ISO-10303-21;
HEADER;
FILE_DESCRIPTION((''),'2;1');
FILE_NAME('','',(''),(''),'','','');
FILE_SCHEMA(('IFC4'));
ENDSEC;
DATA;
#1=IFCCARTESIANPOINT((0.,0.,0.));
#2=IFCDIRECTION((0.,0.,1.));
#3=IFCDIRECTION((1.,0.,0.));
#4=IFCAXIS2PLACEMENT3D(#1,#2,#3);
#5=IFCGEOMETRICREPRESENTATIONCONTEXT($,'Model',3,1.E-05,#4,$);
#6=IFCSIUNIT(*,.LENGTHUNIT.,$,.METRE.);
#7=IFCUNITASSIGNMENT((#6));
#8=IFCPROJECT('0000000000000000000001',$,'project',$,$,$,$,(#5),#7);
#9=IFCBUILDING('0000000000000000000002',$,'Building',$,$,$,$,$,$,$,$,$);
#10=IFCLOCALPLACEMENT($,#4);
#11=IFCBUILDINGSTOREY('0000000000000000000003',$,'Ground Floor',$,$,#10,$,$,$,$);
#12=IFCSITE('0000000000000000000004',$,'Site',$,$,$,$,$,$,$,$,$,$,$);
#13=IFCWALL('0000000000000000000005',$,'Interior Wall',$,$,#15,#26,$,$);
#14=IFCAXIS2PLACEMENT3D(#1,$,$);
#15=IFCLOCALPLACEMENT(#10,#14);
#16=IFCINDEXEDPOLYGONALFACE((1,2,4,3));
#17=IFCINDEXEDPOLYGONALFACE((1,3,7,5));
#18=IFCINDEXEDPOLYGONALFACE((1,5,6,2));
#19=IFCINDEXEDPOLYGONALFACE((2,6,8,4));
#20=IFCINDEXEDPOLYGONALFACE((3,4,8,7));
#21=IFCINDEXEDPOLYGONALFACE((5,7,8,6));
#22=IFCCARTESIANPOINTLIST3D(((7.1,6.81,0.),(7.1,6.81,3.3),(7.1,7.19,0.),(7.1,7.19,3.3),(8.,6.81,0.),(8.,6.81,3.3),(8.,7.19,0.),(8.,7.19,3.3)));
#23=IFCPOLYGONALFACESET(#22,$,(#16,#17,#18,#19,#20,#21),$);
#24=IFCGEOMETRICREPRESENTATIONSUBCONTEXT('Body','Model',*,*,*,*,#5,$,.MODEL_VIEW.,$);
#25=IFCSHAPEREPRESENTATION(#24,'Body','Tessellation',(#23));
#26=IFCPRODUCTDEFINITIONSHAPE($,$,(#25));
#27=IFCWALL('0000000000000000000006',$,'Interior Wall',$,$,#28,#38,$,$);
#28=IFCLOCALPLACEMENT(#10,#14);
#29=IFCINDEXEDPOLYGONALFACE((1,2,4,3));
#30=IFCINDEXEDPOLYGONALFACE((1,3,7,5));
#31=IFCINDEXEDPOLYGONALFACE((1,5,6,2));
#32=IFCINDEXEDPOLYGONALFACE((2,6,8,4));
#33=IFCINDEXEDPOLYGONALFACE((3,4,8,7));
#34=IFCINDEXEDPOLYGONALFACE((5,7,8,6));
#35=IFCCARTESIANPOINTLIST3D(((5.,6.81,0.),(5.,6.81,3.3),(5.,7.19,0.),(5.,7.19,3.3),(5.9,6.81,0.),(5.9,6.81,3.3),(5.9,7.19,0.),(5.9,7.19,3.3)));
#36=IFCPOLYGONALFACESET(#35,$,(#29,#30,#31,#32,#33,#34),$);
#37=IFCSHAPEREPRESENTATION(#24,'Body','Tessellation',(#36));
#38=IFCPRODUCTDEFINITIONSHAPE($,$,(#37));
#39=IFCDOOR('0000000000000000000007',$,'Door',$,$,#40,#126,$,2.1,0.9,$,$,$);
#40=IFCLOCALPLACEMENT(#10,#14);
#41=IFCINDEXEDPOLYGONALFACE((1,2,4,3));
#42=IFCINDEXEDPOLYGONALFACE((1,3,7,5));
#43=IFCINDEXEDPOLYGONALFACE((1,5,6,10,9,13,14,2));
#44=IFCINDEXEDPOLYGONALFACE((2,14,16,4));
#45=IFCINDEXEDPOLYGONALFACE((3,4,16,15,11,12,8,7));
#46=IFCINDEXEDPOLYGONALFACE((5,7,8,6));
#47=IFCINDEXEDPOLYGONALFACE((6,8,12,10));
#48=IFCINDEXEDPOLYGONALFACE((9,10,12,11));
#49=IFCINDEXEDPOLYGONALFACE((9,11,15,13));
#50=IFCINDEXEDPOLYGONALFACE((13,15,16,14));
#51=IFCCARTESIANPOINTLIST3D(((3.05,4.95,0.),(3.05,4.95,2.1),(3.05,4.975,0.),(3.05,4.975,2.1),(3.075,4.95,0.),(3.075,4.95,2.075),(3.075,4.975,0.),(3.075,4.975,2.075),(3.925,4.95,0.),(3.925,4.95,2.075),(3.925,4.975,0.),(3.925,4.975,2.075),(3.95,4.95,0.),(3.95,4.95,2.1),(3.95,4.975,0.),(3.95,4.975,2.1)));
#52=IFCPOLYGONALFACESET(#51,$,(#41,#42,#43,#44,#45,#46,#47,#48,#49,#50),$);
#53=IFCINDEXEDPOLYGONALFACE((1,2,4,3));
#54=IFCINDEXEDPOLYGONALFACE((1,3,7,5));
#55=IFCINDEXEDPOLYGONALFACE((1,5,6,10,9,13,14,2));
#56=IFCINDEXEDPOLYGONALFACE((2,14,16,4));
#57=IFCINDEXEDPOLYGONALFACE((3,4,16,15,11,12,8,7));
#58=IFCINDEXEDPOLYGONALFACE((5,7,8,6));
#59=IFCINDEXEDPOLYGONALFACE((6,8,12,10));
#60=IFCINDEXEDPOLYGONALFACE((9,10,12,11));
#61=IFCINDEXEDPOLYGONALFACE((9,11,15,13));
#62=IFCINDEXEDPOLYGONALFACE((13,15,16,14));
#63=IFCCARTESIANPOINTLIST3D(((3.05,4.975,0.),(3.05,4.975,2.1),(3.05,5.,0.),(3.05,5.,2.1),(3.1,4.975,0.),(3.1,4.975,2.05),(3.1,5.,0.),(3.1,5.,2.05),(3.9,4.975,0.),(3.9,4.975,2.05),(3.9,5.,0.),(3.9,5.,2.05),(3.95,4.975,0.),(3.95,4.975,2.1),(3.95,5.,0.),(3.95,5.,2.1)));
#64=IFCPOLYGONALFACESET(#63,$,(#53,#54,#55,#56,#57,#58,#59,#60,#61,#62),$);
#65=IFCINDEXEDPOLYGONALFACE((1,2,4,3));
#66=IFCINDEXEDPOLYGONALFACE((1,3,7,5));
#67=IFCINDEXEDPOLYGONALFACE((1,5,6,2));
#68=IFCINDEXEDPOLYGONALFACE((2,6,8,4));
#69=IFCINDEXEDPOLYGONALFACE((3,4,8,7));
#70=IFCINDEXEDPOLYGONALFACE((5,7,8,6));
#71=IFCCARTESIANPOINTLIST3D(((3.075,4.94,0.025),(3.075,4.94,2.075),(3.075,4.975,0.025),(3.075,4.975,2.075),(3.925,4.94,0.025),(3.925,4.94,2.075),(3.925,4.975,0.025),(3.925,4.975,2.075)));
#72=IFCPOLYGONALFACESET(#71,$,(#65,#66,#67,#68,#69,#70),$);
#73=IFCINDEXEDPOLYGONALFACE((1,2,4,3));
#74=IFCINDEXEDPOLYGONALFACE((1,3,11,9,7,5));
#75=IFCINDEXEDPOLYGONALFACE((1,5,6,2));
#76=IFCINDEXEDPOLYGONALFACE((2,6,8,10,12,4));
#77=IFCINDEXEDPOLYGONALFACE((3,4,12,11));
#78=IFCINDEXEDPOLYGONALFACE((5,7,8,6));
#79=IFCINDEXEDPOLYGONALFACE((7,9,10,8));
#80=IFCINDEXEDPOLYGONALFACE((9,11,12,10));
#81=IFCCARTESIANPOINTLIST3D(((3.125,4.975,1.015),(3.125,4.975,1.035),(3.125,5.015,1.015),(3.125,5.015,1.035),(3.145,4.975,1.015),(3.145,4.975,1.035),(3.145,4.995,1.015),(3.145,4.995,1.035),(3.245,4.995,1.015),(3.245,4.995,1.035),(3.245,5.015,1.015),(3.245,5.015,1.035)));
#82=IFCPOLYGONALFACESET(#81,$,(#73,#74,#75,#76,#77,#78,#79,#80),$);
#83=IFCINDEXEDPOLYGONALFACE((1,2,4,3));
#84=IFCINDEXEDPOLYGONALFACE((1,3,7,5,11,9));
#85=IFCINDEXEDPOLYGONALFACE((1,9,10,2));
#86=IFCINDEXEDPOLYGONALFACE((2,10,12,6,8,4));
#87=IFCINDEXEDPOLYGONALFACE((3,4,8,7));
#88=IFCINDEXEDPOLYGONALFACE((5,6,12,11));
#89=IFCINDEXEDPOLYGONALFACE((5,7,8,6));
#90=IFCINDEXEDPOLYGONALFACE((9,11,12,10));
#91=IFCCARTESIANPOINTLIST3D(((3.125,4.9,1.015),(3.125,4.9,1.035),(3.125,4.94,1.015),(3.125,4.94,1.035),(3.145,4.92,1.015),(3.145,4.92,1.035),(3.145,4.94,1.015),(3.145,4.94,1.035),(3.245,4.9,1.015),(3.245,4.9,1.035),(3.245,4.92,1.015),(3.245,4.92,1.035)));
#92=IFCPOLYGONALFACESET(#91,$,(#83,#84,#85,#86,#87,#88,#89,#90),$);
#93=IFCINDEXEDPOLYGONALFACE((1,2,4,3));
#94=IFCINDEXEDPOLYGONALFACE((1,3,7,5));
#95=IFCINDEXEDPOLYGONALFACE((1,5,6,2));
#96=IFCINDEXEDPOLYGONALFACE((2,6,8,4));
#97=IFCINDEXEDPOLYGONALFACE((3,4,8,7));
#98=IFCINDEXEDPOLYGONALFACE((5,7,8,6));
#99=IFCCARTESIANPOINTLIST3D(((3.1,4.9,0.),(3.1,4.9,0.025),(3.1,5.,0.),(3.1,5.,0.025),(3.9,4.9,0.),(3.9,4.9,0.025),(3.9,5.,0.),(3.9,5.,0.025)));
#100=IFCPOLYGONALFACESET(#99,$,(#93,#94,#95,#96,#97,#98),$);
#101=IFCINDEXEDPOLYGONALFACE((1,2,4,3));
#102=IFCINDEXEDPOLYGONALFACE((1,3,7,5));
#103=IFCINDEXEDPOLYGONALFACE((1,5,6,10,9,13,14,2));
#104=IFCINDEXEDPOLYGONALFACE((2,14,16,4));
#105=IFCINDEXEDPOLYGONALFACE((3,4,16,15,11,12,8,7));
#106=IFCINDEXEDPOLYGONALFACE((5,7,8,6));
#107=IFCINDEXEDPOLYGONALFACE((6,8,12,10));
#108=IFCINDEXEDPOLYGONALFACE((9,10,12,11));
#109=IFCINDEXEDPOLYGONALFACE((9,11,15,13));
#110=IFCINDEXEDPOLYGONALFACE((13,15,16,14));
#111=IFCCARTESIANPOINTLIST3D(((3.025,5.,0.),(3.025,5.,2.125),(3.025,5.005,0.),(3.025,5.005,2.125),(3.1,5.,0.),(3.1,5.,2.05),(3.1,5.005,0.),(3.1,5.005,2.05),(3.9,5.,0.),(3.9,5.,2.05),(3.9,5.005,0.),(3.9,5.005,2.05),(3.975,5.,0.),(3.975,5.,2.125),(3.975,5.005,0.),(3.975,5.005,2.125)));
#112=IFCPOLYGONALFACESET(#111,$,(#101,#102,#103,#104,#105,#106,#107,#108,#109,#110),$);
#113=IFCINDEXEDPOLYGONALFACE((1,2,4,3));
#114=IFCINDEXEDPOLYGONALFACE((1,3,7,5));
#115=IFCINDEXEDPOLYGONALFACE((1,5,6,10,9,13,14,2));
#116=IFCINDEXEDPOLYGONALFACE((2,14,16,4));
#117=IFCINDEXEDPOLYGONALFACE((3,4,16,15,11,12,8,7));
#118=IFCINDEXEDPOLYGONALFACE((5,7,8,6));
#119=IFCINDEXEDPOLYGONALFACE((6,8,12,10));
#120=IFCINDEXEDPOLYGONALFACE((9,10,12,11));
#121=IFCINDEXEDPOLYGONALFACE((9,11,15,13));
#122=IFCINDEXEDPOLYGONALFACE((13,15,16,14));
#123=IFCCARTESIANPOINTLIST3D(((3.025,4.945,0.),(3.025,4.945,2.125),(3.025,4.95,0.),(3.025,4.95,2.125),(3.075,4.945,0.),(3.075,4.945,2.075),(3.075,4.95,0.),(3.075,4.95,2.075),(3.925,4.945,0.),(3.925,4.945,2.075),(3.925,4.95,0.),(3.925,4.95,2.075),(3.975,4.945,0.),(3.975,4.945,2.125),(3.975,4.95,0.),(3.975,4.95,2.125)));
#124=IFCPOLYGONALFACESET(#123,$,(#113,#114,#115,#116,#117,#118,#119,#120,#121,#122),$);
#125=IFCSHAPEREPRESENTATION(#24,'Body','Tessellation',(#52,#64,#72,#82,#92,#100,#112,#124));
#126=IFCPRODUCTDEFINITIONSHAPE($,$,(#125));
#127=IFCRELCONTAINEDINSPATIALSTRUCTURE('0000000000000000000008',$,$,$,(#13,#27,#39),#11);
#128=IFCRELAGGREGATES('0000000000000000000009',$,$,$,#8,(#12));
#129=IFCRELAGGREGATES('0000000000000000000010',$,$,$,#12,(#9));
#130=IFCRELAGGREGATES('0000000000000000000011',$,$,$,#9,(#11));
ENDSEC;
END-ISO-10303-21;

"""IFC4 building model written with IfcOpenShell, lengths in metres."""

from ifc_helpers import new_model, si_unit, frame, origin_with_axes, place, context, subcontext, project, spatial, line, indexed_curve, outline, extrude, element, save


model = new_model("IFC4")

# Units and contexts
model_context = context("Model", 3, precision=1e-05, world=origin_with_axes())
body_context = subcontext(model_context, "Body", "Model", "MODEL_VIEW")
ifc_project = project(units=[si_unit("LENGTHUNIT", "METRE")], contexts=[model_context])

# Site, building, storey
site = spatial("IfcSite", under=ifc_project, Name="Site")
building = spatial("IfcBuilding", under=site, Name="Building")
storey_placement = place(None, origin_with_axes())
storey = spatial("IfcBuildingStorey", under=building, at=storey_placement, Name="Ground Floor")

# Walls
for number, where, z_axis, x_axis, name in (
    (1, (8.0, 7.0, 0.0), (0.0, 0.0, 1.0), (-1.0, 0.0, 0.0), "Interior Wall"),
    (2, (5.9, 7.0, 0.0), (0.0, 0.0, 1.0), (-1.0, 0.0, 0.0), "Interior Wall"),
):
    element("IfcWall", number, at=place(storey_placement, frame(where, z_axis=z_axis, x_axis=x_axis)), inside=storey, Name=name, context=body_context, shape_type="SweptSolid", body=[
        extrude(outline(indexed_curve([(0.0, 0.0), (0.0, 0.38), (0.9, 0.38), (0.9, 0.0), (0.0, 0.0)], self_intersect=False)), frame((0.0, -0.19, 0.0), z_axis=(0.0, 0.0, 1.0), x_axis=(1.0, 0.0, 0.0)), (0.0, 0.0, 1.0), 3.3),
    ])

# Door
door_1_placement = place(storey_placement, frame((3.95, 5.0, 0.0), z_axis=(0.0, 0.0, 1.0), x_axis=(-1.0, 0.0, 0.0)))
element("IfcDoor", 3, at=door_1_placement, inside=storey, Name="Door", OverallHeight=2.1, OverallWidth=0.9, context=body_context, shape_type="SweptSolid", body=[
    extrude(outline(indexed_curve([(0.0, 0.0), (0.0, 2.1), (0.9, 2.1), (0.9, 0.0), (0.875, 0.0), (0.875, 2.075), (0.025, 2.075), (0.025, 0.0)], segments=[line(1, 2, 3, 4, 5, 6, 7, 8, 1)])), frame((0.0, 0.025, 0.0), z_axis=(0.0, -1.0, 0.0), x_axis=(1.0, 0.0, 0.0)), (0.0, 0.0, -1.0), 0.025),
    extrude(outline(indexed_curve([(0.0, 0.0), (0.0, 2.1), (0.9, 2.1), (0.9, 0.0), (0.85, 0.0), (0.85, 2.05), (0.05, 2.05), (0.05, 0.0)], segments=[line(1, 2, 3, 4, 5, 6, 7, 8, 1)])), frame((0.0, 0.0, 0.0), z_axis=(0.0, -1.0, 0.0), x_axis=(1.0, 0.0, 0.0)), (0.0, 0.0, -1.0), 0.025),
    extrude(outline(indexed_curve([(0.0, 0.0), (0.85, 0.0), (0.85, 0.035), (0.0, 0.035)], segments=[line(1, 2, 3, 4, 1)])), frame((0.025, 0.025, 0.025), z_axis=(0.0, 0.0, 1.0), x_axis=(1.0, 0.0, 0.0)), (0.0, 0.0, 1.0), 2.05),
    extrude(outline(indexed_curve([(0.0, 0.0), (0.0, -0.04), (-0.12, -0.04), (-0.12, -0.02), (-0.02, -0.02), (-0.02, 0.0)], segments=[line(1, 2, 3, 4, 5, 6, 1)])), frame((0.825, 0.025, 1.015), z_axis=(0.0, 0.0, 1.0), x_axis=(1.0, 0.0, 0.0)), (0.0, 0.0, 1.0), 0.02),
    extrude(outline(indexed_curve([(0.0, 0.0), (0.0, 0.04), (-0.12, 0.04), (-0.12, 0.02), (-0.02, 0.02), (-0.02, 0.0)], segments=[line(1, 2, 3, 4, 5, 6, 1)])), frame((0.825, 0.06, 1.015), z_axis=(0.0, 0.0, 1.0), x_axis=(1.0, 0.0, 0.0)), (0.0, 0.0, 1.0), 0.02),
    extrude(outline(indexed_curve([(0.0, 0.0), (0.8, 0.0), (0.8, 0.1), (0.0, 0.1)], segments=[line(1, 2, 3, 4, 1)])), frame((0.05, 0.0, 0.0), z_axis=(0.0, 0.0, 1.0), x_axis=(1.0, 0.0, 0.0)), (0.0, 0.0, 1.0), 0.025),
    extrude(outline(indexed_curve([(0.0, 0.0), (0.0, 2.125), (0.95, 2.125), (0.95, 0.0), (0.875, 0.0), (0.875, 2.05), (0.075, 2.05), (0.075, 0.0)], segments=[line(1, 2, 3, 4, 5, 6, 7, 8, 1)])), frame((-0.025, -0.005, 0.0), z_axis=(0.0, -1.0, 0.0), x_axis=(1.0, 0.0, 0.0)), (0.0, 0.0, -1.0), 0.005),
    extrude(outline(indexed_curve([(0.0, 0.0), (0.0, 2.125), (0.95, 2.125), (0.95, 0.0), (0.9, 0.0), (0.9, 2.075), (0.05, 2.075), (0.05, 0.0)], segments=[line(1, 2, 3, 4, 5, 6, 7, 8, 1)])), frame((-0.025, 0.05, 0.0), z_axis=(0.0, -1.0, 0.0), x_axis=(1.0, 0.0, 0.0)), (0.0, 0.0, -1.0), 0.005),
])

save(model, "model.ifc")
